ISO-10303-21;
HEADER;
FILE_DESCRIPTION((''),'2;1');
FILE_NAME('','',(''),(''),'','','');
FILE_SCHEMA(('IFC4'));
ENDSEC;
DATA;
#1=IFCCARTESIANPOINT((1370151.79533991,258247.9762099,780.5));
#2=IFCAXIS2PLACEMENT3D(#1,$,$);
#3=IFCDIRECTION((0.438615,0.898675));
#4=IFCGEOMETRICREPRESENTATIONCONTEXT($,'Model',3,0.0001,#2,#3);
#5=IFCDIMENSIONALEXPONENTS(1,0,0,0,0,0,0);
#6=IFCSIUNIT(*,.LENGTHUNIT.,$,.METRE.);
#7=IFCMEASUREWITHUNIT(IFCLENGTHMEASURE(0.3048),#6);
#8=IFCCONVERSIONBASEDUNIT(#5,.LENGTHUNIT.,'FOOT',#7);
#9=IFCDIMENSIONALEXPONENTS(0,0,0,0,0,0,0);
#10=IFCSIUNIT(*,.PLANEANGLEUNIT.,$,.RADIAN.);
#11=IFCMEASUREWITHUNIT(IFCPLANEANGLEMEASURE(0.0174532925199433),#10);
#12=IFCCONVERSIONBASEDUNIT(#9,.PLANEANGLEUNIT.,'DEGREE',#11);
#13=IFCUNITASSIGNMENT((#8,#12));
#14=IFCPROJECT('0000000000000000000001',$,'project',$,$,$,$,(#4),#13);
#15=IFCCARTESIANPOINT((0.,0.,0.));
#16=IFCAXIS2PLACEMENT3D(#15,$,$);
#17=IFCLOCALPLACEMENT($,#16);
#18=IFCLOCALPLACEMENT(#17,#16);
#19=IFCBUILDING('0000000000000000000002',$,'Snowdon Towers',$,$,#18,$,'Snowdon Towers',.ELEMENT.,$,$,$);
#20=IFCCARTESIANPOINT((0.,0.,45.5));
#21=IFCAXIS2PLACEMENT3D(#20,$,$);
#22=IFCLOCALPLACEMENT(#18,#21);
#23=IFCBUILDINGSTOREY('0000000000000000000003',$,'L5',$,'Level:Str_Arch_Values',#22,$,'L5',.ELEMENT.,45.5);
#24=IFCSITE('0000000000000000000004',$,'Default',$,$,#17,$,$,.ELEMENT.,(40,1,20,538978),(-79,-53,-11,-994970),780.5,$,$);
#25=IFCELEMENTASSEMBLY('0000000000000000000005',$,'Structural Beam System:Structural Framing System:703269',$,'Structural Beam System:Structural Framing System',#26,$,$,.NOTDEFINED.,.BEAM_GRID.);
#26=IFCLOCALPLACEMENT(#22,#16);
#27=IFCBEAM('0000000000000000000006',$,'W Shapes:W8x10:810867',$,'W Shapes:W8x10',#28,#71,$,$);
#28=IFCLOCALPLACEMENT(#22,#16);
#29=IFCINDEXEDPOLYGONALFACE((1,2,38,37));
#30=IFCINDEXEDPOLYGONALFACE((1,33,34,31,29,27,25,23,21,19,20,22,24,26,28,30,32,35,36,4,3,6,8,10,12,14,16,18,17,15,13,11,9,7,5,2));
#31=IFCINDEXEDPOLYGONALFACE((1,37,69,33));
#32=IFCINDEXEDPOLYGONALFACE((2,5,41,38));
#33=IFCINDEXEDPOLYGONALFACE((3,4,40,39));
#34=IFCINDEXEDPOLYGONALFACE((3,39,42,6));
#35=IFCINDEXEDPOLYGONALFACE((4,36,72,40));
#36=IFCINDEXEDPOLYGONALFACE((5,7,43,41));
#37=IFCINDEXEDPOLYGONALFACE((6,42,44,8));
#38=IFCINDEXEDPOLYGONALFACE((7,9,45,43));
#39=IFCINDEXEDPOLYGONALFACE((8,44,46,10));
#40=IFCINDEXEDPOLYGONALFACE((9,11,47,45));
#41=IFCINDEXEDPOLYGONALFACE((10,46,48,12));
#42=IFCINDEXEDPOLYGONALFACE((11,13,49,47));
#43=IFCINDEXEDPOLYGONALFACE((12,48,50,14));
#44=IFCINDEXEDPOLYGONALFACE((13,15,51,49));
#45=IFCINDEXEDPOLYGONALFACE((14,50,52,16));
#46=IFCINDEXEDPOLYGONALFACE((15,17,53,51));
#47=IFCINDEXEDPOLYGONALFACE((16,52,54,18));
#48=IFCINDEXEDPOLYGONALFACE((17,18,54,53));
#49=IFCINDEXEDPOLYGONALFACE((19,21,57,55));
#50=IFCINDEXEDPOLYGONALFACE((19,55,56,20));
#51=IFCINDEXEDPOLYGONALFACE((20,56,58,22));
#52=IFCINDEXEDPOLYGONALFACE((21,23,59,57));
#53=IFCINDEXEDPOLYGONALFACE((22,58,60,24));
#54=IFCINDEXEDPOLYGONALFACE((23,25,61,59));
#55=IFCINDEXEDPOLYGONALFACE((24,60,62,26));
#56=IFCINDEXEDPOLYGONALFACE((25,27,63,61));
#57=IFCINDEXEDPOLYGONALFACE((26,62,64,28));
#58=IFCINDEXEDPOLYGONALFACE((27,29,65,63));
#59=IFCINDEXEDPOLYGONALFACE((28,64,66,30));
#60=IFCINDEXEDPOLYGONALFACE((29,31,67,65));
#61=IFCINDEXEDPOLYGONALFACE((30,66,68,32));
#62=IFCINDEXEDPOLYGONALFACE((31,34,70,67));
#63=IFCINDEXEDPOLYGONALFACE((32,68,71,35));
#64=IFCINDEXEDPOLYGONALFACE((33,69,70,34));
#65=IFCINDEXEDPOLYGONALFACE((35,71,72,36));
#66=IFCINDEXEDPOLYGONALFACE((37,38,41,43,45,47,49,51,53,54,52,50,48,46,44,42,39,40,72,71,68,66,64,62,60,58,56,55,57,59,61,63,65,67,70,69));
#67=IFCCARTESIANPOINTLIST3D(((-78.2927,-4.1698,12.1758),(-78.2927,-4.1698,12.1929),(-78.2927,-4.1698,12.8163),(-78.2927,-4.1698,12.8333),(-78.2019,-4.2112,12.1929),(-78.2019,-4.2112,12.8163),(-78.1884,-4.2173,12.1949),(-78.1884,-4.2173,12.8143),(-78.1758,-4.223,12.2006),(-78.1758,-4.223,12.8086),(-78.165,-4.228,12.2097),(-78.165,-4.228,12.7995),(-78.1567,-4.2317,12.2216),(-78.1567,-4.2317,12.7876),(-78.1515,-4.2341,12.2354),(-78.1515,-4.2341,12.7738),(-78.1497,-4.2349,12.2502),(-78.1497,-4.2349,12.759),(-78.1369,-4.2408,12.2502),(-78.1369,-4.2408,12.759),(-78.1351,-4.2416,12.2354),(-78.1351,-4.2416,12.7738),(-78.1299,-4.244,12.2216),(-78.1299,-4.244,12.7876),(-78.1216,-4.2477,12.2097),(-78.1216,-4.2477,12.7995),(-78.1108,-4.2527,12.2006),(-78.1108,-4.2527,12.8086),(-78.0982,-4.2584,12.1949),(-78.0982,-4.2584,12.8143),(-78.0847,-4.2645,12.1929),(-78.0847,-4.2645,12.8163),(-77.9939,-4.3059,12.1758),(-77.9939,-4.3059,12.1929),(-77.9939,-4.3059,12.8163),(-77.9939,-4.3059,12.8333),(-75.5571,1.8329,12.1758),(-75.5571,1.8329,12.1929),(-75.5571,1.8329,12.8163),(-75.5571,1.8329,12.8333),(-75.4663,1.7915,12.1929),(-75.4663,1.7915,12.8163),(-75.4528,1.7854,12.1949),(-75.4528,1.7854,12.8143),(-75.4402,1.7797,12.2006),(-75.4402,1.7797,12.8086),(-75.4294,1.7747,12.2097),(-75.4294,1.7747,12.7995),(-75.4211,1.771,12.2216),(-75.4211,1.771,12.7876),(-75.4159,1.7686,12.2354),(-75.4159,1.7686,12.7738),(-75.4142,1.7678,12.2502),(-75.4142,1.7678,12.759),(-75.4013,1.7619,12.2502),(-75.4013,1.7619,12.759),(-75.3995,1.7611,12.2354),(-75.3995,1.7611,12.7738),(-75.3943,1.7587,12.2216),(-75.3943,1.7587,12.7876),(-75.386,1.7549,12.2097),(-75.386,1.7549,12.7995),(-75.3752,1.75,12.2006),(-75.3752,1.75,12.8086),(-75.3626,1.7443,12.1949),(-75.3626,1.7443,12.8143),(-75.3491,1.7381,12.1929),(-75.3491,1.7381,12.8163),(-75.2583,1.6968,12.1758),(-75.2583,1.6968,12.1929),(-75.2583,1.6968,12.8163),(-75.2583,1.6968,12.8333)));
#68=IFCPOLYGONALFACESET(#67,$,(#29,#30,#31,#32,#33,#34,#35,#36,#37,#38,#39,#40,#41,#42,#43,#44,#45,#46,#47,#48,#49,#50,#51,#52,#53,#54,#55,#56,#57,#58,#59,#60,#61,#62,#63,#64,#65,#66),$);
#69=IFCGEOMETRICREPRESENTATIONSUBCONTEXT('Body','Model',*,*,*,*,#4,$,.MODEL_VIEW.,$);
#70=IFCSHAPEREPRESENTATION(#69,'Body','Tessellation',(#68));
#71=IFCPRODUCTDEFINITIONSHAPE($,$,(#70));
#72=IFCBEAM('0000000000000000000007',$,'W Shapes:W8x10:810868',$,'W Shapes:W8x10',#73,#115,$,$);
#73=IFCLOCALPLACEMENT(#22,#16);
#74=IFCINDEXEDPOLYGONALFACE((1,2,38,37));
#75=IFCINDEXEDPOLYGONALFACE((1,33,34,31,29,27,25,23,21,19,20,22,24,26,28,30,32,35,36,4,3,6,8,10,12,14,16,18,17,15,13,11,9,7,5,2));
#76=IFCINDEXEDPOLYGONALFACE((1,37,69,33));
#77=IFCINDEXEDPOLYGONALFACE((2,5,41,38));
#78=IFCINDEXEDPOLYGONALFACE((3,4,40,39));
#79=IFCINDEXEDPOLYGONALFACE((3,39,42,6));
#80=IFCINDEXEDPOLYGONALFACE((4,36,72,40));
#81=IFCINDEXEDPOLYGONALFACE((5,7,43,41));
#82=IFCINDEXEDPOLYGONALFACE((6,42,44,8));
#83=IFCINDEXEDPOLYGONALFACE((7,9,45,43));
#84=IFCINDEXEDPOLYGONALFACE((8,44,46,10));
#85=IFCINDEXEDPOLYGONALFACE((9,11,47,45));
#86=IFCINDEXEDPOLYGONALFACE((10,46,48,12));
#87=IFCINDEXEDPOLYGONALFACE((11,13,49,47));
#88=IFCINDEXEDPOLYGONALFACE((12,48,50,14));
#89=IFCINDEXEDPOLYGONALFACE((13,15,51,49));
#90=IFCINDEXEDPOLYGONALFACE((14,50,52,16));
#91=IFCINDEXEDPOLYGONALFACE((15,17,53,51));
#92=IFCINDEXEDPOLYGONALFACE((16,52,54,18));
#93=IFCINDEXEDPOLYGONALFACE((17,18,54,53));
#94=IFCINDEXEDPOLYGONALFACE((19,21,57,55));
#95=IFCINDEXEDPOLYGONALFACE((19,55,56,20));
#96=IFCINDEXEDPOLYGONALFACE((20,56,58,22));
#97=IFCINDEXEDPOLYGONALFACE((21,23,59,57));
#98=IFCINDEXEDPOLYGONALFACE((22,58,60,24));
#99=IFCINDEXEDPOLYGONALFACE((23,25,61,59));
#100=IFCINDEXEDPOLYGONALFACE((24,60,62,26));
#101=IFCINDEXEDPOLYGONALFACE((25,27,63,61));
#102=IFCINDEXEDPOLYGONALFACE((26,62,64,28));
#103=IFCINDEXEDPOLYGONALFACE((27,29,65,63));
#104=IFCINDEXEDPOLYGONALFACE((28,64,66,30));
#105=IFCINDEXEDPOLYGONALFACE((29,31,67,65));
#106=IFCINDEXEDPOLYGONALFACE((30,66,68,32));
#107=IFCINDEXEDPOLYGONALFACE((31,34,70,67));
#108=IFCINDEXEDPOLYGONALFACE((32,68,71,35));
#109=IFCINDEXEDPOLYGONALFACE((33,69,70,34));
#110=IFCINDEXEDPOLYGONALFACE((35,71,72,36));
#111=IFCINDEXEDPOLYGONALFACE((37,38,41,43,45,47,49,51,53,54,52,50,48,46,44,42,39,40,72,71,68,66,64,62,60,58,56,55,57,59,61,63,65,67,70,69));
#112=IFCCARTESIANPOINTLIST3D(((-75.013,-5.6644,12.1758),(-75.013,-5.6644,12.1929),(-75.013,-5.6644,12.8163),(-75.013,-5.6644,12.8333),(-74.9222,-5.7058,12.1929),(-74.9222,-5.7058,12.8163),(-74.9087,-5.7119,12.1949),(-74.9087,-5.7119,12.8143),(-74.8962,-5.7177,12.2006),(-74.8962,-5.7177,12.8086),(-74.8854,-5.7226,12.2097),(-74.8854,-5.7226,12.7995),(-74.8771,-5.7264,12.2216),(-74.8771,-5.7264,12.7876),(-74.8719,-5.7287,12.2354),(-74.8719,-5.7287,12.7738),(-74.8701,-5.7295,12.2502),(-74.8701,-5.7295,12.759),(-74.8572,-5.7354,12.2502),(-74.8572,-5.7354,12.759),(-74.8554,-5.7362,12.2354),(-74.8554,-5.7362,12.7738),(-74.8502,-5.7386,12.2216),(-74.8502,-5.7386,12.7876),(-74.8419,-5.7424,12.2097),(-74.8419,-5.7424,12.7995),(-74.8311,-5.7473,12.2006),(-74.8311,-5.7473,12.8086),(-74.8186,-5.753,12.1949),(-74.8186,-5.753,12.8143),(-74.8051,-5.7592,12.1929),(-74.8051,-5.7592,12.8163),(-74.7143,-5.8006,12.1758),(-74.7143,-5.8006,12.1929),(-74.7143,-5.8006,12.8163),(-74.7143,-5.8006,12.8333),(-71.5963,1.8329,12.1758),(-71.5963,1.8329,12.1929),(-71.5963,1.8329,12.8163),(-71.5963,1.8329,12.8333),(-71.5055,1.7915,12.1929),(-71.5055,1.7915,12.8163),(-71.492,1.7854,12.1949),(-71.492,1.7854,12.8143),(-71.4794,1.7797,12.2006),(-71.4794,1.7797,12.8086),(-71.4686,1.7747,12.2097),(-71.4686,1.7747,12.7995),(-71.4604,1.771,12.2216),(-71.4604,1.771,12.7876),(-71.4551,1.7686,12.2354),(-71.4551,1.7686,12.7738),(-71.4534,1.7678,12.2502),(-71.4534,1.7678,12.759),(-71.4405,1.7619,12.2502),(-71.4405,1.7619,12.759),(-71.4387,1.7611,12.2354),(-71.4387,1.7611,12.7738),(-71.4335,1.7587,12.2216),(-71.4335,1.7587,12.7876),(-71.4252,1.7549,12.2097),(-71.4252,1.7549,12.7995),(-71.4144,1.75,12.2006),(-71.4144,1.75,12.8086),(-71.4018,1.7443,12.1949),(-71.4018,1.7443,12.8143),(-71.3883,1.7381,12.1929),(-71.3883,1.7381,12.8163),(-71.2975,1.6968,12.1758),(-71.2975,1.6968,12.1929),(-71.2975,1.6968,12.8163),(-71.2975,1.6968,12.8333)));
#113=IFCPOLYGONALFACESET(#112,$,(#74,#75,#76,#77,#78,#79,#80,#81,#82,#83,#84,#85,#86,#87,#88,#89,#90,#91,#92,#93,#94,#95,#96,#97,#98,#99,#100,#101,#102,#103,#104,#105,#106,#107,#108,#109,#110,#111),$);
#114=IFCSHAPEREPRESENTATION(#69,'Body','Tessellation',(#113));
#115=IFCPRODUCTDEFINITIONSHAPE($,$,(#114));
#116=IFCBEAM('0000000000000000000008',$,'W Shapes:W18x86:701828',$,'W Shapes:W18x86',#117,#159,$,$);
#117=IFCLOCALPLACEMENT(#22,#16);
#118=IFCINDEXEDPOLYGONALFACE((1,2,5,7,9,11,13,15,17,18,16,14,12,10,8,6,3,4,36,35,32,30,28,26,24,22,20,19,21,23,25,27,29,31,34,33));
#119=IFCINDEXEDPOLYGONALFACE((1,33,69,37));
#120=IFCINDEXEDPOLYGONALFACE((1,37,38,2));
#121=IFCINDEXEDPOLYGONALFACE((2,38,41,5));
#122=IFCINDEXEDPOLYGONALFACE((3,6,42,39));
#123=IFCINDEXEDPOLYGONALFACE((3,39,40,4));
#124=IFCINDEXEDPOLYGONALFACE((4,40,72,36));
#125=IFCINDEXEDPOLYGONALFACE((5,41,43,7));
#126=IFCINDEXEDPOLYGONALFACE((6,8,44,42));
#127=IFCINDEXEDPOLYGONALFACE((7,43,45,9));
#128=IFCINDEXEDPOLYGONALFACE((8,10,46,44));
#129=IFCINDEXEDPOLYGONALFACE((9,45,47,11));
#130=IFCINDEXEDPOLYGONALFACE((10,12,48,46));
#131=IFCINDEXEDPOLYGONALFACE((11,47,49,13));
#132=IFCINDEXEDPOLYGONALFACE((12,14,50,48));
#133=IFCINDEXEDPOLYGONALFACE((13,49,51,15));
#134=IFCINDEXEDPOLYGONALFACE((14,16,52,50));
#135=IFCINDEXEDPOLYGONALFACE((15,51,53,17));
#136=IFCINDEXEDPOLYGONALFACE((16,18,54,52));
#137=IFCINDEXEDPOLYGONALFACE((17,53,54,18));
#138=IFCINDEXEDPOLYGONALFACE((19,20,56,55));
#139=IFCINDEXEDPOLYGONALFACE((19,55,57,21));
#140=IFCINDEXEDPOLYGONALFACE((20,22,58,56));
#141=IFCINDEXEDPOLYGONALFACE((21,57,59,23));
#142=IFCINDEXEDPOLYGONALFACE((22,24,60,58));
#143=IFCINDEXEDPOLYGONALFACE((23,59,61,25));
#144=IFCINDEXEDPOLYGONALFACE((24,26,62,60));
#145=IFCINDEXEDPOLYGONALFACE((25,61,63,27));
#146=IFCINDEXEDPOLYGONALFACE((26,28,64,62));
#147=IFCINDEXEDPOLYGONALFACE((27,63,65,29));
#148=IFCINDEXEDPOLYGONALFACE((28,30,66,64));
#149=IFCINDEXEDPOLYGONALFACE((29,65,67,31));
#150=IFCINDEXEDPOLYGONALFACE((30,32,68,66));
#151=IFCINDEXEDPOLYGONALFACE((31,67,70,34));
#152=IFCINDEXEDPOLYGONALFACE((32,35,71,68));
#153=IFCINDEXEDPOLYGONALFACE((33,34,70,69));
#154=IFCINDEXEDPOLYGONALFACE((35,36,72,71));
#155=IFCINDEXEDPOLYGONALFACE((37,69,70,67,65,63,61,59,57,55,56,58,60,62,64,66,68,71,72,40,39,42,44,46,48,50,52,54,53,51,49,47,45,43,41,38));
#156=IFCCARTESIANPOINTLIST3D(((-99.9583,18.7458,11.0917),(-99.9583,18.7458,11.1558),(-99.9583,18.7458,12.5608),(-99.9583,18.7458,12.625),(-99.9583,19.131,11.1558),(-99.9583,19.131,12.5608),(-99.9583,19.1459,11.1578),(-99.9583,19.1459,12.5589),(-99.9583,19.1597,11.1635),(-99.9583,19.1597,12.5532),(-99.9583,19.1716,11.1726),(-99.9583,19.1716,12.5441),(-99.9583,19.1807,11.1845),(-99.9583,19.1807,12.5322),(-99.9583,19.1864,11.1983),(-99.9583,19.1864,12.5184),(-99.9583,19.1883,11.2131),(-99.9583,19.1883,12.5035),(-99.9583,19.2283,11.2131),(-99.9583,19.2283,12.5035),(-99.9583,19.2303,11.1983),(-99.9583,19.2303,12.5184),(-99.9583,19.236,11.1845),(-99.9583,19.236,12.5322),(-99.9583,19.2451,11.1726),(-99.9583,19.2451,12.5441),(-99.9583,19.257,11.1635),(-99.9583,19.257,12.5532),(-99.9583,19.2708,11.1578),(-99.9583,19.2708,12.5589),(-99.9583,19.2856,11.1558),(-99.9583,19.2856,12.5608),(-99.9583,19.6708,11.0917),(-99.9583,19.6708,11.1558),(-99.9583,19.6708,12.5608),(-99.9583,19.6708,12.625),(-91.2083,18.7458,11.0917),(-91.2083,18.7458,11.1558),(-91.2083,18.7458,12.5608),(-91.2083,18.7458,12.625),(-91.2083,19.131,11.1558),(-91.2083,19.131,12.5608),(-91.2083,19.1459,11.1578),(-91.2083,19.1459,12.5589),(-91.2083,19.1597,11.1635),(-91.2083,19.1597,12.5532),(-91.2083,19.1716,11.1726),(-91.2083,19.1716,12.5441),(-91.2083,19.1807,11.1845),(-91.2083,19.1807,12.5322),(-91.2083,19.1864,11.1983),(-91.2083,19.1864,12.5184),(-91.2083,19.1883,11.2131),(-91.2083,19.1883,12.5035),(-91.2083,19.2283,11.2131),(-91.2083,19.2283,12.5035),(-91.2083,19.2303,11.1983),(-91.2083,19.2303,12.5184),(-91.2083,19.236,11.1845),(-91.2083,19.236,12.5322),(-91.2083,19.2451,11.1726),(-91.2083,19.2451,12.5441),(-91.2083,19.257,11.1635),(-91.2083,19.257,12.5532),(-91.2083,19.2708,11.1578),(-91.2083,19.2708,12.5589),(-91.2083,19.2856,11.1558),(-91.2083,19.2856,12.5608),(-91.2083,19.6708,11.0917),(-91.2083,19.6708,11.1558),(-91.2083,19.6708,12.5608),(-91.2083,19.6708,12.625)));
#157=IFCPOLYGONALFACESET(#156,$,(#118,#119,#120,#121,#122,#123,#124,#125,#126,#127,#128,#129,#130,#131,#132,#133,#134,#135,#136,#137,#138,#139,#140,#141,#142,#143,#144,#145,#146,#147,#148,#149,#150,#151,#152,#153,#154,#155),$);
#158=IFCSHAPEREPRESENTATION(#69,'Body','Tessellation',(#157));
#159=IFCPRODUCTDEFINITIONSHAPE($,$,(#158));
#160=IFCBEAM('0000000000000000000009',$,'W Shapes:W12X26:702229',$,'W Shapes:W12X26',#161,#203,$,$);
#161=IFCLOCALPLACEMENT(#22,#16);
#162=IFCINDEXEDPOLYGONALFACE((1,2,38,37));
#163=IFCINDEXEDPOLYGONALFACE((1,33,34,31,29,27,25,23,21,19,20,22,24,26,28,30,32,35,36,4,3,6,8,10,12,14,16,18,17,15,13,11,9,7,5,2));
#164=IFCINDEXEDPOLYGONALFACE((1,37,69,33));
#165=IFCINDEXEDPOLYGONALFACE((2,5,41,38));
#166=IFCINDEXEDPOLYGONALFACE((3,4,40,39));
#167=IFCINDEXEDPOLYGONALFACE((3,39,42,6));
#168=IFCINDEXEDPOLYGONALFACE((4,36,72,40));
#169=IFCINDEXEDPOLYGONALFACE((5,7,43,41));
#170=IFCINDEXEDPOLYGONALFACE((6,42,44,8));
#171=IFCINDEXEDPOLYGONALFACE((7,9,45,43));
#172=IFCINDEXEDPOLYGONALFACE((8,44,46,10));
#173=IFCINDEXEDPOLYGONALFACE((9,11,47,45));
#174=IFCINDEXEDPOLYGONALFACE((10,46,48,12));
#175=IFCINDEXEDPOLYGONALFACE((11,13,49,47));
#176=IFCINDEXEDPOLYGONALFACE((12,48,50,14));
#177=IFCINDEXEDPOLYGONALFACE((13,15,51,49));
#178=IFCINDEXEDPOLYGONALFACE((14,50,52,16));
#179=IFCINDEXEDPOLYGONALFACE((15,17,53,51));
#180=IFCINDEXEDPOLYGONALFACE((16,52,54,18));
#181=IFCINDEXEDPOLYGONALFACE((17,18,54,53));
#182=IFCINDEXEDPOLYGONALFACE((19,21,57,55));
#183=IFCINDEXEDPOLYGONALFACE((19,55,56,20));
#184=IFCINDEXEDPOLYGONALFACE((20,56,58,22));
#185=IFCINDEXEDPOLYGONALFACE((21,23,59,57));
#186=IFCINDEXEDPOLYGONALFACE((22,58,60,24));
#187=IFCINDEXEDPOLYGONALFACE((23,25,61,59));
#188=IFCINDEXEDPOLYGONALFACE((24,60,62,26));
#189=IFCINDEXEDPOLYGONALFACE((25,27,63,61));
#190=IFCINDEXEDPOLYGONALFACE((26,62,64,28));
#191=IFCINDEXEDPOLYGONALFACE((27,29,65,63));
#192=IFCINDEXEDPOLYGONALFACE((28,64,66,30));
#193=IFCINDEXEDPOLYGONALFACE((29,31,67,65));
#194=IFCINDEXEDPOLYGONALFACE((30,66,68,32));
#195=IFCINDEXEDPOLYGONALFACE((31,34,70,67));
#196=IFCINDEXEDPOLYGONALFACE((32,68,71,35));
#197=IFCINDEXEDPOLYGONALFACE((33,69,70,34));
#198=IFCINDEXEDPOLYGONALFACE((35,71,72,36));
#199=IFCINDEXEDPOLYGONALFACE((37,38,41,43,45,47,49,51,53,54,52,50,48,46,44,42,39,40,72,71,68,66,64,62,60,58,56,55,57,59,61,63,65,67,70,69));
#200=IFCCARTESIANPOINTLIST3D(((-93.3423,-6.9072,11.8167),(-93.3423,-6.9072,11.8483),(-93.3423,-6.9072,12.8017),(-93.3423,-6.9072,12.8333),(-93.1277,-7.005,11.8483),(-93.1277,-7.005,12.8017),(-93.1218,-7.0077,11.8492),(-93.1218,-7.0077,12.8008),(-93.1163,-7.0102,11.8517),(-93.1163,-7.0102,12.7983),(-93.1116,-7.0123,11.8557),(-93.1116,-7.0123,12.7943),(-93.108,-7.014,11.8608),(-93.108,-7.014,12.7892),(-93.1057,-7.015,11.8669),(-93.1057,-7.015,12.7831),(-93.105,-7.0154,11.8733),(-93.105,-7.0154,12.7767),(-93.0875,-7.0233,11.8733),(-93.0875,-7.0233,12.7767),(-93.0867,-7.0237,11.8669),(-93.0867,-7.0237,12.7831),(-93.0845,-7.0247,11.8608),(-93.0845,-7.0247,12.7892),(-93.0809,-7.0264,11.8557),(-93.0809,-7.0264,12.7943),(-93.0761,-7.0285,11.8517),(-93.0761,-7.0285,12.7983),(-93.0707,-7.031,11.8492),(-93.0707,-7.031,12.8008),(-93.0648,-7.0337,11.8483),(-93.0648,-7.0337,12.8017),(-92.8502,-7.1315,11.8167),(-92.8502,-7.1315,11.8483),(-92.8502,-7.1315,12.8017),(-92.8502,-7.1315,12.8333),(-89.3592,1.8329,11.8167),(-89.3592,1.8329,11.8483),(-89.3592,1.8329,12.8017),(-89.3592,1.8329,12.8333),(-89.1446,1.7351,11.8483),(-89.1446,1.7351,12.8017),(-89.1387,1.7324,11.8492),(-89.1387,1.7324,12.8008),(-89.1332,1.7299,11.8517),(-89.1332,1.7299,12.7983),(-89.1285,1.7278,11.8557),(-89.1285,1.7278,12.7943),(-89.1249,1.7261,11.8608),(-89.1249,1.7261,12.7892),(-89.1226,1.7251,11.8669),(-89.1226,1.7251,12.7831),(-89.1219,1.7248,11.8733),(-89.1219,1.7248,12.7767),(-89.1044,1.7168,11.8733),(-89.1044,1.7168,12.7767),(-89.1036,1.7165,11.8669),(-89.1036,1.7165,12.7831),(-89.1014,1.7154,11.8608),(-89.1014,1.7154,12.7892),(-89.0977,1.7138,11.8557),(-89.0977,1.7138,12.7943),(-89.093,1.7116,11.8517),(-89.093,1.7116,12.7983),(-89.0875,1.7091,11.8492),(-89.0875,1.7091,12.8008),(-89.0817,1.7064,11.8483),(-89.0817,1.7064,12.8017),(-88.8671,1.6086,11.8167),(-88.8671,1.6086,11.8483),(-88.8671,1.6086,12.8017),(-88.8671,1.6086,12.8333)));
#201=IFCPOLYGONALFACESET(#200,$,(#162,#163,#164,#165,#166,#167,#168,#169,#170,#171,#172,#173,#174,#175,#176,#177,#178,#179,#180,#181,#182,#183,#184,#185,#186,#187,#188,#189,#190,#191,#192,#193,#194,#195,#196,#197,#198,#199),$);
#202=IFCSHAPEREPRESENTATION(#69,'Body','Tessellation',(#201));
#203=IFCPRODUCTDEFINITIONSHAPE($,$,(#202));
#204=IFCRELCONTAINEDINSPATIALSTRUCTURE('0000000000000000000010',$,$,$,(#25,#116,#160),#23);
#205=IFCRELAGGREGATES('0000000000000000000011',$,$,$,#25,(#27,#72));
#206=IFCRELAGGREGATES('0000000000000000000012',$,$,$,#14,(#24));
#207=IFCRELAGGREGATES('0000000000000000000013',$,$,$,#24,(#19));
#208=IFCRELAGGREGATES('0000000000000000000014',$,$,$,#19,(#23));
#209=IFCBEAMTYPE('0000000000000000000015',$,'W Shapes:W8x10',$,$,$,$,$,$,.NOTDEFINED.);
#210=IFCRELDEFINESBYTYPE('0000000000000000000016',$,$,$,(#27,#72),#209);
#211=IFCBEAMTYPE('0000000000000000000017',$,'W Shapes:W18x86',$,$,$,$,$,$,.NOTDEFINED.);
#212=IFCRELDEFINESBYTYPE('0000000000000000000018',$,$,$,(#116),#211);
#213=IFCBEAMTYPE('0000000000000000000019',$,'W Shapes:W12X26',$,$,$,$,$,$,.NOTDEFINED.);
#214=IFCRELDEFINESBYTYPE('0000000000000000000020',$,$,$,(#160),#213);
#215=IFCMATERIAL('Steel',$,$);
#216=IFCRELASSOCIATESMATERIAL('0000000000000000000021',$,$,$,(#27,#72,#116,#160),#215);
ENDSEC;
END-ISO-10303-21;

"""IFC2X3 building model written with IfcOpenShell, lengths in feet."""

from ifc_helpers import new_model, entity, si_unit, converted_unit, direction, frame, frame_2d, origin, place, context, subcontext, project, spatial, i_section, extrude, material, type_object, element, aggregate, save


model = new_model("IFC2X3")

# Units and contexts
model_context = context("Model", 3, precision=0.0001, world=frame((1370151.79533991, 258247.9762099, 780.5)), true_north=direction((0.438615, 0.898675)))
body_context = subcontext(model_context, "Body", "Model", "MODEL_VIEW")
ifc_project = project(units=[converted_unit("LENGTHUNIT", "FOOT", entity("IfcLengthMeasure", 0.3048), si_unit("LENGTHUNIT", "METRE"), dimensions=[1, 0, 0, 0, 0, 0, 0]), converted_unit("PLANEANGLEUNIT", "DEGREE", entity("IfcPlaneAngleMeasure", 0.0174532925199433), si_unit("PLANEANGLEUNIT", "RADIAN"), dimensions=[0, 0, 0, 0, 0, 0, 0])], contexts=[model_context])

# Site, building, storey
site_placement = place(None, origin())
site = spatial("IfcSite", under=ifc_project, at=site_placement, Name="Default", CompositionType="ELEMENT", RefLatitude=(40, 1, 20, 538978), RefLongitude=(-79, -53, -11, -994970), RefElevation=780.5)
building_placement = place(site_placement, origin())
building = spatial("IfcBuilding", under=site, at=building_placement, Name="Snowdon Towers", LongName="Snowdon Towers", CompositionType="ELEMENT")
storey_placement = place(building_placement, frame((0.0, 0.0, 45.5)))
storey = spatial("IfcBuildingStorey", under=building, at=storey_placement, Name="L5", ObjectType="Level:Str_Arch_Values", LongName="L5", CompositionType="ELEMENT", Elevation=45.5)

# Shared definitions
ifc_material = material(Name="Steel")

# Element assembly, beams
beam_type_1 = type_object("IfcBeamType", Name="W Shapes:W8x10", PredefinedType="NOTDEFINED")
assembly_1_placement = place(storey_placement, origin())
assembly_1 = element("IfcElementAssembly", 1, at=assembly_1_placement, inside=storey, Name="Structural Beam System:Structural Framing System:703269", ObjectType="Structural Beam System:Structural Framing System", AssemblyPlace="NOTDEFINED", PredefinedType="BEAM_GRID")
beam_1_placement = place(assembly_1_placement, frame((-78.2727, -4.5218, 12.8333), z_axis=(0.0, 0.0, 1.0), x_axis=(0.414693, 0.909961, 0.0)))
beam_1 = element("IfcBeam", 2, at=beam_1_placement, type_object=beam_type_1, material=ifc_material, Name="W Shapes:W8x10:810867", ObjectType="W Shapes:W8x10", context=body_context, shape_type="SweptSolid", body=[
    extrude(i_section(OverallWidth=0.3283, OverallDepth=0.6575, WebThickness=0.0142, FlangeThickness=0.0171, FilletRadius=0.0573, at=frame_2d((0.0, 0.0), x_axis=(0.0, 1.0))), frame((0.3121, 0.0, -0.3288), z_axis=(1.0, 0.0, 0.0), x_axis=(0.0, 0.0, -1.0)), (0.0, 0.0, 1.0), 6.5966),
])
beam_2_placement = place(assembly_1_placement, frame((-74.9931, -6.0165, 12.8333), z_axis=(0.0, 0.0, 1.0), x_axis=(0.414693, 0.909961, 0.0)))
beam_2 = element("IfcBeam", 3, at=beam_2_placement, type_object=beam_type_1, material=ifc_material, Name="W Shapes:W8x10:810868", ObjectType="W Shapes:W8x10", context=body_context, shape_type="SweptSolid", body=[
    extrude(i_section(OverallWidth=0.3283, OverallDepth=0.6575, WebThickness=0.0142, FlangeThickness=0.0171, FilletRadius=0.0573, at=frame_2d((0.0, 0.0), x_axis=(0.0, 1.0))), frame((0.3121, 0.0, -0.3288), z_axis=(1.0, 0.0, 0.0), x_axis=(0.0, 0.0, -1.0)), (0.0, 0.0, 1.0), 8.2392),
])
aggregate(assembly_1, [beam_1, beam_2])

# Beams
beam_type_2 = type_object("IfcBeamType", Name="W Shapes:W18x86", PredefinedType="NOTDEFINED")
beam_3_placement = place(storey_placement, frame((-99.9583, 19.2083, 12.8333)))
element("IfcBeam", 4, at=beam_3_placement, inside=storey, type_object=beam_type_2, material=ifc_material, Name="W Shapes:W18x86:701828", ObjectType="W Shapes:W18x86", context=body_context, shape_type="SweptSolid", body=[
    extrude(i_section(OverallWidth=0.925, OverallDepth=1.5333, WebThickness=0.04, FlangeThickness=0.0642, FilletRadius=0.0573, at=frame_2d((0.0, 0.0), x_axis=(0.0, 1.0))), frame((0.0, 0.0, -0.975), z_axis=(1.0, 0.0, 0.0), x_axis=(0.0, 0.0, -1.0)), (0.0, 0.0, 1.0), 8.75),
])
beam_type_3 = type_object("IfcBeamType", Name="W Shapes:W12X26", PredefinedType="NOTDEFINED")
beam_4_placement = place(storey_placement, frame((-93.2257, -7.3033, 12.8333), z_axis=(0.0, 0.0, 1.0), x_axis=(0.414693, 0.909961, 0.0)))
element("IfcBeam", 5, at=beam_4_placement, inside=storey, type_object=beam_type_3, material=ifc_material, Name="W Shapes:W12X26:702229", ObjectType="W Shapes:W12X26", context=body_context, shape_type="SweptSolid", body=[
    extrude(i_section(OverallWidth=0.5408, OverallDepth=1.0167, WebThickness=0.0192, FlangeThickness=0.0317, FilletRadius=0.025, at=frame_2d((0.0, 0.0), x_axis=(0.0, 1.0))), frame((0.3121, 0.0, -0.5083), z_axis=(1.0, 0.0, 0.0), x_axis=(0.0, 0.0, -1.0)), (0.0, 0.0, 1.0), 9.605),
])

save(model, "model.ifc")
